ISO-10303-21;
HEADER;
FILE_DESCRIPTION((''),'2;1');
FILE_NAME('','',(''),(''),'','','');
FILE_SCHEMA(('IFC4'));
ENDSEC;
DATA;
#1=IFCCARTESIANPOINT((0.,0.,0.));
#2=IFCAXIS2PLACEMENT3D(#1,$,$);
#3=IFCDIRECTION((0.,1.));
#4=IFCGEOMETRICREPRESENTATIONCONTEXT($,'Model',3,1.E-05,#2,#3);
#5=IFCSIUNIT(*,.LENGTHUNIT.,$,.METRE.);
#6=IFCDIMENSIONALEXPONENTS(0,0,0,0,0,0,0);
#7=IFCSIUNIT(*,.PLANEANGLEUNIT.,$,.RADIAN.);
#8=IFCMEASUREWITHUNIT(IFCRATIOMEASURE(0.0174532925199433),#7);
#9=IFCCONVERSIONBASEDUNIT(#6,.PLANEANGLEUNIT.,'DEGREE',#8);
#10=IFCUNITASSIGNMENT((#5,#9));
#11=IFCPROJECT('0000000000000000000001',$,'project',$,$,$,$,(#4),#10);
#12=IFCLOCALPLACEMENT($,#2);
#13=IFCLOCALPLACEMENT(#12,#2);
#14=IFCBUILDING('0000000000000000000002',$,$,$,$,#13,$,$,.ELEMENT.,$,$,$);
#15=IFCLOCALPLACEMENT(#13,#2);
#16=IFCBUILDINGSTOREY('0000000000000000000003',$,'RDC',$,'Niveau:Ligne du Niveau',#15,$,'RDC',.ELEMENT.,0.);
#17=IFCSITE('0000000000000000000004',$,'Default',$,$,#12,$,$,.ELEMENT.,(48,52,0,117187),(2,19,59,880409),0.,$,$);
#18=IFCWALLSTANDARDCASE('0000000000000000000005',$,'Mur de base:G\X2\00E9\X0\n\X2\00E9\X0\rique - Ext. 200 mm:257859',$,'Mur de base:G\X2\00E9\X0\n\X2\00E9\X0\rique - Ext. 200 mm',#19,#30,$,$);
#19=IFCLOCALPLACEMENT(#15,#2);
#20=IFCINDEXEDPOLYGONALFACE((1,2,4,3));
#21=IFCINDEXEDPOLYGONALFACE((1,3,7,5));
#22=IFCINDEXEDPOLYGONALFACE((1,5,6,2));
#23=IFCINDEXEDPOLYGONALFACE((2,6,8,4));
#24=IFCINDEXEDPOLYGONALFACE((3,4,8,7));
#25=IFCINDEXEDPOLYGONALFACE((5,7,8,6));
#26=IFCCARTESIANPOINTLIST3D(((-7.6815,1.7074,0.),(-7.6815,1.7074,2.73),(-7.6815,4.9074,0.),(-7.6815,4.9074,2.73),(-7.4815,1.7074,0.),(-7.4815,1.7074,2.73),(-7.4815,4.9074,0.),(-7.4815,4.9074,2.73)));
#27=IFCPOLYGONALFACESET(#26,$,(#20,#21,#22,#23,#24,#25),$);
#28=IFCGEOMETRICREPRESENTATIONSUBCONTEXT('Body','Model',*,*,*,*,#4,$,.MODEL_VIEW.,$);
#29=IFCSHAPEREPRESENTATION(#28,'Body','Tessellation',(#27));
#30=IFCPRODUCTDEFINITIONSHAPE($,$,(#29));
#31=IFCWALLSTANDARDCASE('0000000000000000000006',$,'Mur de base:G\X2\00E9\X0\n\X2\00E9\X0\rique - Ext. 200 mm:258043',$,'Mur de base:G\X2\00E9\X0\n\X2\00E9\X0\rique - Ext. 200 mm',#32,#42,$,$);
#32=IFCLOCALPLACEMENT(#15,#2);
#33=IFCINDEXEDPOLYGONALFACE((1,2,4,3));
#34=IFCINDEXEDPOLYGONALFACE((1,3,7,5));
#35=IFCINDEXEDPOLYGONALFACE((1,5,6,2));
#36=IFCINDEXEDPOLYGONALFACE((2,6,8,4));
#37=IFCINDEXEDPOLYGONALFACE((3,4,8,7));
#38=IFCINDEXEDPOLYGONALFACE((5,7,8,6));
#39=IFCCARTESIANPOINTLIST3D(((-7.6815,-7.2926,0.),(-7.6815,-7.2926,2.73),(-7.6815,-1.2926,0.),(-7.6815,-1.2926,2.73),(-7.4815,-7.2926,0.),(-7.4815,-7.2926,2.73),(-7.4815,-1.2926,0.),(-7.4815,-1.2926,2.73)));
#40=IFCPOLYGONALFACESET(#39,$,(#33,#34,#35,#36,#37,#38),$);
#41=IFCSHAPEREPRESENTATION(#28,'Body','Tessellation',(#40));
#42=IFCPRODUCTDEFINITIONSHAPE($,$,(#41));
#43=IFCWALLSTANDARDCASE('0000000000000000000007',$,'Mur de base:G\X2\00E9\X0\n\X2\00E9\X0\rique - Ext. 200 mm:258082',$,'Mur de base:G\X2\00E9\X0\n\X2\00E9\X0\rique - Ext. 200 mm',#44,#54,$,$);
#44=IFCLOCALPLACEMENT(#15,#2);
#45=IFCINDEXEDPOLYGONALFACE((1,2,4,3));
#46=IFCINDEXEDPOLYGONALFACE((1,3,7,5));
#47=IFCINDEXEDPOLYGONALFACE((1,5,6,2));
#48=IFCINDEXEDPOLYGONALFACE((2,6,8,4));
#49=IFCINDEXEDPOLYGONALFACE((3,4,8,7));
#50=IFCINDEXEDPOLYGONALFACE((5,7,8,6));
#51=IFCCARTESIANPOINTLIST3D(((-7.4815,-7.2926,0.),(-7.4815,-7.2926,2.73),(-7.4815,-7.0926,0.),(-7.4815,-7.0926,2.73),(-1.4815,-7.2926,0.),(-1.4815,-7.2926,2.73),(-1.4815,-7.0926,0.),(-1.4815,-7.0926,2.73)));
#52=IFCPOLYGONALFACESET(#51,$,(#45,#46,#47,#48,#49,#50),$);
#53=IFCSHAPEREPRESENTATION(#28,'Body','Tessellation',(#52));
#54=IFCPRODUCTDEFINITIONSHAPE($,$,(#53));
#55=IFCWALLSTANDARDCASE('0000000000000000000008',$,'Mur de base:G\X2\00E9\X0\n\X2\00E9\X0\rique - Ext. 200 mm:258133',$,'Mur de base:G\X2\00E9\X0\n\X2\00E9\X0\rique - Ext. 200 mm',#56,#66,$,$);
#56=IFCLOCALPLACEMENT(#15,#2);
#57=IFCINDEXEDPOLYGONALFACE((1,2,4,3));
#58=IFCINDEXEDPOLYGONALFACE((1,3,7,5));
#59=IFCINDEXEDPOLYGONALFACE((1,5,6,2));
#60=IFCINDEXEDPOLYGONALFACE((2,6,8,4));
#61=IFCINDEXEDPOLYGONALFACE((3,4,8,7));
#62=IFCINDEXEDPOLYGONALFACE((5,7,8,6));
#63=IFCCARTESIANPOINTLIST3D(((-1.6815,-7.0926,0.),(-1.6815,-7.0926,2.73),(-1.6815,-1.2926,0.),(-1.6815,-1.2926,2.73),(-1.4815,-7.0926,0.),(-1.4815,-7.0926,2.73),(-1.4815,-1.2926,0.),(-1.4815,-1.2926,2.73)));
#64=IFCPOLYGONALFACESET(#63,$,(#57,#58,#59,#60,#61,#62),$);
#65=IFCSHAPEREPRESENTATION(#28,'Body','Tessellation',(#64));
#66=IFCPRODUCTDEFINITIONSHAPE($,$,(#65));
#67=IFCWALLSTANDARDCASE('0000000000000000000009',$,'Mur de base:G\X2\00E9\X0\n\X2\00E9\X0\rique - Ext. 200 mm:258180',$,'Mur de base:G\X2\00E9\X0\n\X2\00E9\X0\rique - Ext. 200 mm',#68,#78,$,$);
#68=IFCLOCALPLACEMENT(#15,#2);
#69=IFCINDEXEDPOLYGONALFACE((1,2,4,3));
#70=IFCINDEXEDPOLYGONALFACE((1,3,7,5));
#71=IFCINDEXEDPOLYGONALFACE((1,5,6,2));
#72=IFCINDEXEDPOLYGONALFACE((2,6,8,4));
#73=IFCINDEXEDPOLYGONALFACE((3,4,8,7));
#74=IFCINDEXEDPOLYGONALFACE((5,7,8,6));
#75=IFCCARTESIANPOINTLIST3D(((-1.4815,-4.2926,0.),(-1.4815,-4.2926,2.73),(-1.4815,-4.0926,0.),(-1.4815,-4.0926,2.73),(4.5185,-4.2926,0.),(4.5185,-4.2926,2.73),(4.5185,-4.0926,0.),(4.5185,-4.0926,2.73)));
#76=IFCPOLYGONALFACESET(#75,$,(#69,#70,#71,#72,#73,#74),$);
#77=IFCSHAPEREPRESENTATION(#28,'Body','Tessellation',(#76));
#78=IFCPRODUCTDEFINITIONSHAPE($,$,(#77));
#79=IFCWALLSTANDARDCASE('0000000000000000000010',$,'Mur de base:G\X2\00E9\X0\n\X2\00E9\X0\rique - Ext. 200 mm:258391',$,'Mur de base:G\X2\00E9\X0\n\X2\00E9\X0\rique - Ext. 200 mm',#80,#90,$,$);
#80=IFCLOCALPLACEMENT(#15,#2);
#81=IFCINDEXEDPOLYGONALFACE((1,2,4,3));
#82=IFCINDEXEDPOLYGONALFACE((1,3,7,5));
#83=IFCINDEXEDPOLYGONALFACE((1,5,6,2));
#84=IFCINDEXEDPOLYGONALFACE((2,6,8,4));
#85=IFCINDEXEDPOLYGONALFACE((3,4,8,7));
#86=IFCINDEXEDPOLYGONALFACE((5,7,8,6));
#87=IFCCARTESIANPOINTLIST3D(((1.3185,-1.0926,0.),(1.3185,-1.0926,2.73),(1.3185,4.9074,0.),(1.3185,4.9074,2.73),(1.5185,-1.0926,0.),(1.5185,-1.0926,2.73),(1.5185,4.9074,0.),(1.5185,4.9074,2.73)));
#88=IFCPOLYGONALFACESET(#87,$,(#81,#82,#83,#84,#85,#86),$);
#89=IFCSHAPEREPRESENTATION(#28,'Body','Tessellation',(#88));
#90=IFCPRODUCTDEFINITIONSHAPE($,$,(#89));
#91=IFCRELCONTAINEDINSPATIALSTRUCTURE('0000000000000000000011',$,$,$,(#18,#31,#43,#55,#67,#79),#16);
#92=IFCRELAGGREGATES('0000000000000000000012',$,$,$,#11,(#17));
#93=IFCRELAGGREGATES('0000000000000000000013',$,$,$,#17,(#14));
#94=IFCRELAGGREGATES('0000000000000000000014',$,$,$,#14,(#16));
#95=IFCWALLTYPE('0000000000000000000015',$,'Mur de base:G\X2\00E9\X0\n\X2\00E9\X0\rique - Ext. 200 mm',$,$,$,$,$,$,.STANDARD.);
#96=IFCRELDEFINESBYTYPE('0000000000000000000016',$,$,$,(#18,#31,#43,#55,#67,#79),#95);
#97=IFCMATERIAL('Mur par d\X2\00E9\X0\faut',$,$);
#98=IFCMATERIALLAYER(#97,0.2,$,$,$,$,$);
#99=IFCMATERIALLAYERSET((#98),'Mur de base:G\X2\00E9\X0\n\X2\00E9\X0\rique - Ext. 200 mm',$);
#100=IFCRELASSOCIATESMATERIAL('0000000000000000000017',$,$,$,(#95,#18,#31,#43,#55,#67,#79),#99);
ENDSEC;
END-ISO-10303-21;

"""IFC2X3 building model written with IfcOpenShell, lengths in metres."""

from ifc_helpers import new_model, entity, si_unit, converted_unit, direction, frame, frame_2d, origin, place, context, subcontext, project, spatial, polyline, rectangle, extrude, clip, bounded_halfspace, material, layer, layer_set, layer_usage, type_object, element, save


model = new_model("IFC2X3")

# Units and contexts
model_context = context("Model", 3, precision=1e-05, world=origin(), true_north=direction((0.0, 1.0)))
body_context = subcontext(model_context, "Body", "Model", "MODEL_VIEW")
ifc_project = project(units=[si_unit("LENGTHUNIT", "METRE"), converted_unit("PLANEANGLEUNIT", "DEGREE", entity("IfcRatioMeasure", 0.0174532925199433), si_unit("PLANEANGLEUNIT", "RADIAN"), dimensions=[0, 0, 0, 0, 0, 0, 0])], contexts=[model_context])

# Site, building, storey
site_placement = place(None, origin())
site = spatial("IfcSite", under=ifc_project, at=site_placement, Name="Default", CompositionType="ELEMENT", RefLatitude=(48, 52, 0, 117187), RefLongitude=(2, 19, 59, 880409), RefElevation=0.0)
building_placement = place(site_placement, origin())
building = spatial("IfcBuilding", under=site, at=building_placement, CompositionType="ELEMENT")
storey_placement = place(building_placement, origin())
storey = spatial("IfcBuildingStorey", under=building, at=storey_placement, Name="RDC", ObjectType="Niveau:Ligne du Niveau", LongName="RDC", CompositionType="ELEMENT", Elevation=0.0)

# Walls
ifc_material_1 = material(Name="Mur par défaut")
ifc_layer_1 = layer(ifc_material_1, 0.2)
ifc_layer_set_1 = layer_set([ifc_layer_1], Name="Mur de base:Générique - Ext. 200 mm")
ifc_layer_usage_1 = layer_usage(ifc_layer_set_1, "AXIS2", "NEGATIVE", 0.1)
wall_type = type_object("IfcWallType", Name="Mur de base:Générique - Ext. 200 mm", PredefinedType="STANDARD", material=ifc_layer_set_1)
wall_1_placement = place(storey_placement, frame((-7.5815, 4.9074, 0.0), z_axis=(0.0, 0.0, 1.0), x_axis=(0.0, -1.0, 0.0)))
element("IfcWallStandardCase", 1, at=wall_1_placement, inside=storey, type_object=wall_type, material=ifc_layer_usage_1, Name="Mur de base:Générique - Ext. 200 mm:257859", ObjectType="Mur de base:Générique - Ext. 200 mm", context=body_context, shape_type="Clipping", body=[
    clip(extrude(rectangle(XDim=3.2, YDim=0.2, at=frame_2d((1.6, 0.0), x_axis=(-1.0, 0.0))), origin(), (0.0, 0.0, 1.0), 2.73), bounded_halfspace(frame((0.0, -0.1, 2.73), z_axis=(0.0, 0.0, -1.0), x_axis=(-1.0, 0.0, 0.0)), True, frame((0.0, -0.1, 2.73)), polyline([(0.0, 0.0), (3.2, 0.0), (3.2, 0.2), (3.0, 0.2), (0.2, 0.2), (0.0, 0.2), (0.0, 0.0)]))),
])
ifc_layer_usage_2 = layer_usage(ifc_layer_set_1, "AXIS2", "NEGATIVE", 0.1)
wall_2_placement = place(storey_placement, frame((-7.5815, -1.2926, 0.0), z_axis=(0.0, 0.0, 1.0), x_axis=(0.0, -1.0, 0.0)))
element("IfcWallStandardCase", 2, at=wall_2_placement, inside=storey, type_object=wall_type, material=ifc_layer_usage_2, Name="Mur de base:Générique - Ext. 200 mm:258043", ObjectType="Mur de base:Générique - Ext. 200 mm", context=body_context, shape_type="Clipping", body=[
    clip(extrude(rectangle(XDim=6.0, YDim=0.2, at=frame_2d((3.0, 0.0), x_axis=(-1.0, 0.0))), origin(), (0.0, 0.0, 1.0), 2.73), bounded_halfspace(frame((0.0, -0.1, 2.73), z_axis=(0.0, 0.0, -1.0), x_axis=(-1.0, 0.0, 0.0)), True, frame((0.0, -0.1, 2.73)), polyline([(0.0, 0.0), (6.0, 0.0), (6.0, 0.2), (5.8, 0.2), (0.0, 0.2), (0.0, 0.0)]))),
])
ifc_layer_usage_3 = layer_usage(ifc_layer_set_1, "AXIS2", "NEGATIVE", 0.1)
wall_3_placement = place(storey_placement, frame((-7.4815, -7.1926, 0.0)))
element("IfcWallStandardCase", 3, at=wall_3_placement, inside=storey, type_object=wall_type, material=ifc_layer_usage_3, Name="Mur de base:Générique - Ext. 200 mm:258082", ObjectType="Mur de base:Générique - Ext. 200 mm", context=body_context, shape_type="Clipping", body=[
    clip(extrude(rectangle(XDim=6.0, YDim=0.2, at=frame_2d((3.0, 0.0), x_axis=(-1.0, 0.0))), origin(), (0.0, 0.0, 1.0), 2.73), bounded_halfspace(frame((0.0, -0.1, 2.73), z_axis=(0.0, 0.0, -1.0), x_axis=(0.0, 1.0, 0.0)), True, frame((0.0, -0.1, 2.73)), polyline([(0.0, 0.0), (6.0, 0.0), (6.0, 0.2), (5.8, 0.2), (0.0, 0.2), (0.0, 0.0)]))),
])
ifc_layer_usage_4 = layer_usage(ifc_layer_set_1, "AXIS2", "NEGATIVE", 0.1)
wall_4_placement = place(storey_placement, frame((-1.5815, -7.0926, 0.0), z_axis=(0.0, 0.0, 1.0), x_axis=(0.0, 1.0, 0.0)))
element("IfcWallStandardCase", 4, at=wall_4_placement, inside=storey, type_object=wall_type, material=ifc_layer_usage_4, Name="Mur de base:Générique - Ext. 200 mm:258133", ObjectType="Mur de base:Générique - Ext. 200 mm", context=body_context, shape_type="Clipping", body=[
    clip(extrude(rectangle(XDim=5.8, YDim=0.2, at=frame_2d((2.9, 0.0), x_axis=(-1.0, 0.0))), origin(), (0.0, 0.0, 1.0), 2.73), bounded_halfspace(frame((0.0, -0.1, 2.73), z_axis=(0.0, 0.0, -1.0), x_axis=(1.0, 0.0, 0.0)), True, frame((0.0, -0.1, 2.73)), polyline([(0.0, 0.0), (1.4, 0.0), (2.8, 0.0), (3.0, 0.0), (5.8, 0.0), (5.8, 0.2), (0.0, 0.2), (0.0, 0.0)]))),
])
ifc_layer_usage_5 = layer_usage(ifc_layer_set_1, "AXIS2", "NEGATIVE", 0.1)
wall_5_placement = place(storey_placement, frame((-1.4815, -4.1926, 0.0)))
element("IfcWallStandardCase", 5, at=wall_5_placement, inside=storey, type_object=wall_type, material=ifc_layer_usage_5, Name="Mur de base:Générique - Ext. 200 mm:258180", ObjectType="Mur de base:Générique - Ext. 200 mm", context=body_context, shape_type="Clipping", body=[
    clip(extrude(rectangle(XDim=6.0, YDim=0.2, at=frame_2d((3.0, 0.0), x_axis=(-1.0, 0.0))), origin(), (0.0, 0.0, 1.0), 2.73), bounded_halfspace(frame((0.0, -0.1, 2.73), z_axis=(0.0, 0.0, -1.0), x_axis=(0.0, 1.0, 0.0)), True, frame((0.0, -0.1, 2.73)), polyline([(0.0, 0.0), (6.0, 0.0), (6.0, 0.2), (5.8, 0.2), (0.0, 0.2), (0.0, 0.0)]))),
])
ifc_layer_usage_6 = layer_usage(ifc_layer_set_1, "AXIS2", "NEGATIVE", 0.1)
wall_6_placement = place(storey_placement, frame((1.4185, -1.0926, 0.0), z_axis=(0.0, 0.0, 1.0), x_axis=(0.0, 1.0, 0.0)))
element("IfcWallStandardCase", 6, at=wall_6_placement, inside=storey, type_object=wall_type, material=ifc_layer_usage_6, Name="Mur de base:Générique - Ext. 200 mm:258391", ObjectType="Mur de base:Générique - Ext. 200 mm", context=body_context, shape_type="Clipping", body=[
    clip(extrude(rectangle(XDim=6.0, YDim=0.2, at=frame_2d((3.0, 0.0), x_axis=(-1.0, 0.0))), origin(), (0.0, 0.0, 1.0), 2.73), bounded_halfspace(frame((0.0, -0.1, 2.73), z_axis=(0.0, 0.0, -1.0), x_axis=(1.0, 0.0, 0.0)), True, frame((0.0, -0.1, 2.73)), polyline([(0.0, 0.0), (6.0, 0.0), (6.0, 0.2), (5.8, 0.2), (3.0, 0.2), (2.8, 0.2), (0.0, 0.2), (0.0, 0.0)]))),
])

save(model, "model.ifc")
